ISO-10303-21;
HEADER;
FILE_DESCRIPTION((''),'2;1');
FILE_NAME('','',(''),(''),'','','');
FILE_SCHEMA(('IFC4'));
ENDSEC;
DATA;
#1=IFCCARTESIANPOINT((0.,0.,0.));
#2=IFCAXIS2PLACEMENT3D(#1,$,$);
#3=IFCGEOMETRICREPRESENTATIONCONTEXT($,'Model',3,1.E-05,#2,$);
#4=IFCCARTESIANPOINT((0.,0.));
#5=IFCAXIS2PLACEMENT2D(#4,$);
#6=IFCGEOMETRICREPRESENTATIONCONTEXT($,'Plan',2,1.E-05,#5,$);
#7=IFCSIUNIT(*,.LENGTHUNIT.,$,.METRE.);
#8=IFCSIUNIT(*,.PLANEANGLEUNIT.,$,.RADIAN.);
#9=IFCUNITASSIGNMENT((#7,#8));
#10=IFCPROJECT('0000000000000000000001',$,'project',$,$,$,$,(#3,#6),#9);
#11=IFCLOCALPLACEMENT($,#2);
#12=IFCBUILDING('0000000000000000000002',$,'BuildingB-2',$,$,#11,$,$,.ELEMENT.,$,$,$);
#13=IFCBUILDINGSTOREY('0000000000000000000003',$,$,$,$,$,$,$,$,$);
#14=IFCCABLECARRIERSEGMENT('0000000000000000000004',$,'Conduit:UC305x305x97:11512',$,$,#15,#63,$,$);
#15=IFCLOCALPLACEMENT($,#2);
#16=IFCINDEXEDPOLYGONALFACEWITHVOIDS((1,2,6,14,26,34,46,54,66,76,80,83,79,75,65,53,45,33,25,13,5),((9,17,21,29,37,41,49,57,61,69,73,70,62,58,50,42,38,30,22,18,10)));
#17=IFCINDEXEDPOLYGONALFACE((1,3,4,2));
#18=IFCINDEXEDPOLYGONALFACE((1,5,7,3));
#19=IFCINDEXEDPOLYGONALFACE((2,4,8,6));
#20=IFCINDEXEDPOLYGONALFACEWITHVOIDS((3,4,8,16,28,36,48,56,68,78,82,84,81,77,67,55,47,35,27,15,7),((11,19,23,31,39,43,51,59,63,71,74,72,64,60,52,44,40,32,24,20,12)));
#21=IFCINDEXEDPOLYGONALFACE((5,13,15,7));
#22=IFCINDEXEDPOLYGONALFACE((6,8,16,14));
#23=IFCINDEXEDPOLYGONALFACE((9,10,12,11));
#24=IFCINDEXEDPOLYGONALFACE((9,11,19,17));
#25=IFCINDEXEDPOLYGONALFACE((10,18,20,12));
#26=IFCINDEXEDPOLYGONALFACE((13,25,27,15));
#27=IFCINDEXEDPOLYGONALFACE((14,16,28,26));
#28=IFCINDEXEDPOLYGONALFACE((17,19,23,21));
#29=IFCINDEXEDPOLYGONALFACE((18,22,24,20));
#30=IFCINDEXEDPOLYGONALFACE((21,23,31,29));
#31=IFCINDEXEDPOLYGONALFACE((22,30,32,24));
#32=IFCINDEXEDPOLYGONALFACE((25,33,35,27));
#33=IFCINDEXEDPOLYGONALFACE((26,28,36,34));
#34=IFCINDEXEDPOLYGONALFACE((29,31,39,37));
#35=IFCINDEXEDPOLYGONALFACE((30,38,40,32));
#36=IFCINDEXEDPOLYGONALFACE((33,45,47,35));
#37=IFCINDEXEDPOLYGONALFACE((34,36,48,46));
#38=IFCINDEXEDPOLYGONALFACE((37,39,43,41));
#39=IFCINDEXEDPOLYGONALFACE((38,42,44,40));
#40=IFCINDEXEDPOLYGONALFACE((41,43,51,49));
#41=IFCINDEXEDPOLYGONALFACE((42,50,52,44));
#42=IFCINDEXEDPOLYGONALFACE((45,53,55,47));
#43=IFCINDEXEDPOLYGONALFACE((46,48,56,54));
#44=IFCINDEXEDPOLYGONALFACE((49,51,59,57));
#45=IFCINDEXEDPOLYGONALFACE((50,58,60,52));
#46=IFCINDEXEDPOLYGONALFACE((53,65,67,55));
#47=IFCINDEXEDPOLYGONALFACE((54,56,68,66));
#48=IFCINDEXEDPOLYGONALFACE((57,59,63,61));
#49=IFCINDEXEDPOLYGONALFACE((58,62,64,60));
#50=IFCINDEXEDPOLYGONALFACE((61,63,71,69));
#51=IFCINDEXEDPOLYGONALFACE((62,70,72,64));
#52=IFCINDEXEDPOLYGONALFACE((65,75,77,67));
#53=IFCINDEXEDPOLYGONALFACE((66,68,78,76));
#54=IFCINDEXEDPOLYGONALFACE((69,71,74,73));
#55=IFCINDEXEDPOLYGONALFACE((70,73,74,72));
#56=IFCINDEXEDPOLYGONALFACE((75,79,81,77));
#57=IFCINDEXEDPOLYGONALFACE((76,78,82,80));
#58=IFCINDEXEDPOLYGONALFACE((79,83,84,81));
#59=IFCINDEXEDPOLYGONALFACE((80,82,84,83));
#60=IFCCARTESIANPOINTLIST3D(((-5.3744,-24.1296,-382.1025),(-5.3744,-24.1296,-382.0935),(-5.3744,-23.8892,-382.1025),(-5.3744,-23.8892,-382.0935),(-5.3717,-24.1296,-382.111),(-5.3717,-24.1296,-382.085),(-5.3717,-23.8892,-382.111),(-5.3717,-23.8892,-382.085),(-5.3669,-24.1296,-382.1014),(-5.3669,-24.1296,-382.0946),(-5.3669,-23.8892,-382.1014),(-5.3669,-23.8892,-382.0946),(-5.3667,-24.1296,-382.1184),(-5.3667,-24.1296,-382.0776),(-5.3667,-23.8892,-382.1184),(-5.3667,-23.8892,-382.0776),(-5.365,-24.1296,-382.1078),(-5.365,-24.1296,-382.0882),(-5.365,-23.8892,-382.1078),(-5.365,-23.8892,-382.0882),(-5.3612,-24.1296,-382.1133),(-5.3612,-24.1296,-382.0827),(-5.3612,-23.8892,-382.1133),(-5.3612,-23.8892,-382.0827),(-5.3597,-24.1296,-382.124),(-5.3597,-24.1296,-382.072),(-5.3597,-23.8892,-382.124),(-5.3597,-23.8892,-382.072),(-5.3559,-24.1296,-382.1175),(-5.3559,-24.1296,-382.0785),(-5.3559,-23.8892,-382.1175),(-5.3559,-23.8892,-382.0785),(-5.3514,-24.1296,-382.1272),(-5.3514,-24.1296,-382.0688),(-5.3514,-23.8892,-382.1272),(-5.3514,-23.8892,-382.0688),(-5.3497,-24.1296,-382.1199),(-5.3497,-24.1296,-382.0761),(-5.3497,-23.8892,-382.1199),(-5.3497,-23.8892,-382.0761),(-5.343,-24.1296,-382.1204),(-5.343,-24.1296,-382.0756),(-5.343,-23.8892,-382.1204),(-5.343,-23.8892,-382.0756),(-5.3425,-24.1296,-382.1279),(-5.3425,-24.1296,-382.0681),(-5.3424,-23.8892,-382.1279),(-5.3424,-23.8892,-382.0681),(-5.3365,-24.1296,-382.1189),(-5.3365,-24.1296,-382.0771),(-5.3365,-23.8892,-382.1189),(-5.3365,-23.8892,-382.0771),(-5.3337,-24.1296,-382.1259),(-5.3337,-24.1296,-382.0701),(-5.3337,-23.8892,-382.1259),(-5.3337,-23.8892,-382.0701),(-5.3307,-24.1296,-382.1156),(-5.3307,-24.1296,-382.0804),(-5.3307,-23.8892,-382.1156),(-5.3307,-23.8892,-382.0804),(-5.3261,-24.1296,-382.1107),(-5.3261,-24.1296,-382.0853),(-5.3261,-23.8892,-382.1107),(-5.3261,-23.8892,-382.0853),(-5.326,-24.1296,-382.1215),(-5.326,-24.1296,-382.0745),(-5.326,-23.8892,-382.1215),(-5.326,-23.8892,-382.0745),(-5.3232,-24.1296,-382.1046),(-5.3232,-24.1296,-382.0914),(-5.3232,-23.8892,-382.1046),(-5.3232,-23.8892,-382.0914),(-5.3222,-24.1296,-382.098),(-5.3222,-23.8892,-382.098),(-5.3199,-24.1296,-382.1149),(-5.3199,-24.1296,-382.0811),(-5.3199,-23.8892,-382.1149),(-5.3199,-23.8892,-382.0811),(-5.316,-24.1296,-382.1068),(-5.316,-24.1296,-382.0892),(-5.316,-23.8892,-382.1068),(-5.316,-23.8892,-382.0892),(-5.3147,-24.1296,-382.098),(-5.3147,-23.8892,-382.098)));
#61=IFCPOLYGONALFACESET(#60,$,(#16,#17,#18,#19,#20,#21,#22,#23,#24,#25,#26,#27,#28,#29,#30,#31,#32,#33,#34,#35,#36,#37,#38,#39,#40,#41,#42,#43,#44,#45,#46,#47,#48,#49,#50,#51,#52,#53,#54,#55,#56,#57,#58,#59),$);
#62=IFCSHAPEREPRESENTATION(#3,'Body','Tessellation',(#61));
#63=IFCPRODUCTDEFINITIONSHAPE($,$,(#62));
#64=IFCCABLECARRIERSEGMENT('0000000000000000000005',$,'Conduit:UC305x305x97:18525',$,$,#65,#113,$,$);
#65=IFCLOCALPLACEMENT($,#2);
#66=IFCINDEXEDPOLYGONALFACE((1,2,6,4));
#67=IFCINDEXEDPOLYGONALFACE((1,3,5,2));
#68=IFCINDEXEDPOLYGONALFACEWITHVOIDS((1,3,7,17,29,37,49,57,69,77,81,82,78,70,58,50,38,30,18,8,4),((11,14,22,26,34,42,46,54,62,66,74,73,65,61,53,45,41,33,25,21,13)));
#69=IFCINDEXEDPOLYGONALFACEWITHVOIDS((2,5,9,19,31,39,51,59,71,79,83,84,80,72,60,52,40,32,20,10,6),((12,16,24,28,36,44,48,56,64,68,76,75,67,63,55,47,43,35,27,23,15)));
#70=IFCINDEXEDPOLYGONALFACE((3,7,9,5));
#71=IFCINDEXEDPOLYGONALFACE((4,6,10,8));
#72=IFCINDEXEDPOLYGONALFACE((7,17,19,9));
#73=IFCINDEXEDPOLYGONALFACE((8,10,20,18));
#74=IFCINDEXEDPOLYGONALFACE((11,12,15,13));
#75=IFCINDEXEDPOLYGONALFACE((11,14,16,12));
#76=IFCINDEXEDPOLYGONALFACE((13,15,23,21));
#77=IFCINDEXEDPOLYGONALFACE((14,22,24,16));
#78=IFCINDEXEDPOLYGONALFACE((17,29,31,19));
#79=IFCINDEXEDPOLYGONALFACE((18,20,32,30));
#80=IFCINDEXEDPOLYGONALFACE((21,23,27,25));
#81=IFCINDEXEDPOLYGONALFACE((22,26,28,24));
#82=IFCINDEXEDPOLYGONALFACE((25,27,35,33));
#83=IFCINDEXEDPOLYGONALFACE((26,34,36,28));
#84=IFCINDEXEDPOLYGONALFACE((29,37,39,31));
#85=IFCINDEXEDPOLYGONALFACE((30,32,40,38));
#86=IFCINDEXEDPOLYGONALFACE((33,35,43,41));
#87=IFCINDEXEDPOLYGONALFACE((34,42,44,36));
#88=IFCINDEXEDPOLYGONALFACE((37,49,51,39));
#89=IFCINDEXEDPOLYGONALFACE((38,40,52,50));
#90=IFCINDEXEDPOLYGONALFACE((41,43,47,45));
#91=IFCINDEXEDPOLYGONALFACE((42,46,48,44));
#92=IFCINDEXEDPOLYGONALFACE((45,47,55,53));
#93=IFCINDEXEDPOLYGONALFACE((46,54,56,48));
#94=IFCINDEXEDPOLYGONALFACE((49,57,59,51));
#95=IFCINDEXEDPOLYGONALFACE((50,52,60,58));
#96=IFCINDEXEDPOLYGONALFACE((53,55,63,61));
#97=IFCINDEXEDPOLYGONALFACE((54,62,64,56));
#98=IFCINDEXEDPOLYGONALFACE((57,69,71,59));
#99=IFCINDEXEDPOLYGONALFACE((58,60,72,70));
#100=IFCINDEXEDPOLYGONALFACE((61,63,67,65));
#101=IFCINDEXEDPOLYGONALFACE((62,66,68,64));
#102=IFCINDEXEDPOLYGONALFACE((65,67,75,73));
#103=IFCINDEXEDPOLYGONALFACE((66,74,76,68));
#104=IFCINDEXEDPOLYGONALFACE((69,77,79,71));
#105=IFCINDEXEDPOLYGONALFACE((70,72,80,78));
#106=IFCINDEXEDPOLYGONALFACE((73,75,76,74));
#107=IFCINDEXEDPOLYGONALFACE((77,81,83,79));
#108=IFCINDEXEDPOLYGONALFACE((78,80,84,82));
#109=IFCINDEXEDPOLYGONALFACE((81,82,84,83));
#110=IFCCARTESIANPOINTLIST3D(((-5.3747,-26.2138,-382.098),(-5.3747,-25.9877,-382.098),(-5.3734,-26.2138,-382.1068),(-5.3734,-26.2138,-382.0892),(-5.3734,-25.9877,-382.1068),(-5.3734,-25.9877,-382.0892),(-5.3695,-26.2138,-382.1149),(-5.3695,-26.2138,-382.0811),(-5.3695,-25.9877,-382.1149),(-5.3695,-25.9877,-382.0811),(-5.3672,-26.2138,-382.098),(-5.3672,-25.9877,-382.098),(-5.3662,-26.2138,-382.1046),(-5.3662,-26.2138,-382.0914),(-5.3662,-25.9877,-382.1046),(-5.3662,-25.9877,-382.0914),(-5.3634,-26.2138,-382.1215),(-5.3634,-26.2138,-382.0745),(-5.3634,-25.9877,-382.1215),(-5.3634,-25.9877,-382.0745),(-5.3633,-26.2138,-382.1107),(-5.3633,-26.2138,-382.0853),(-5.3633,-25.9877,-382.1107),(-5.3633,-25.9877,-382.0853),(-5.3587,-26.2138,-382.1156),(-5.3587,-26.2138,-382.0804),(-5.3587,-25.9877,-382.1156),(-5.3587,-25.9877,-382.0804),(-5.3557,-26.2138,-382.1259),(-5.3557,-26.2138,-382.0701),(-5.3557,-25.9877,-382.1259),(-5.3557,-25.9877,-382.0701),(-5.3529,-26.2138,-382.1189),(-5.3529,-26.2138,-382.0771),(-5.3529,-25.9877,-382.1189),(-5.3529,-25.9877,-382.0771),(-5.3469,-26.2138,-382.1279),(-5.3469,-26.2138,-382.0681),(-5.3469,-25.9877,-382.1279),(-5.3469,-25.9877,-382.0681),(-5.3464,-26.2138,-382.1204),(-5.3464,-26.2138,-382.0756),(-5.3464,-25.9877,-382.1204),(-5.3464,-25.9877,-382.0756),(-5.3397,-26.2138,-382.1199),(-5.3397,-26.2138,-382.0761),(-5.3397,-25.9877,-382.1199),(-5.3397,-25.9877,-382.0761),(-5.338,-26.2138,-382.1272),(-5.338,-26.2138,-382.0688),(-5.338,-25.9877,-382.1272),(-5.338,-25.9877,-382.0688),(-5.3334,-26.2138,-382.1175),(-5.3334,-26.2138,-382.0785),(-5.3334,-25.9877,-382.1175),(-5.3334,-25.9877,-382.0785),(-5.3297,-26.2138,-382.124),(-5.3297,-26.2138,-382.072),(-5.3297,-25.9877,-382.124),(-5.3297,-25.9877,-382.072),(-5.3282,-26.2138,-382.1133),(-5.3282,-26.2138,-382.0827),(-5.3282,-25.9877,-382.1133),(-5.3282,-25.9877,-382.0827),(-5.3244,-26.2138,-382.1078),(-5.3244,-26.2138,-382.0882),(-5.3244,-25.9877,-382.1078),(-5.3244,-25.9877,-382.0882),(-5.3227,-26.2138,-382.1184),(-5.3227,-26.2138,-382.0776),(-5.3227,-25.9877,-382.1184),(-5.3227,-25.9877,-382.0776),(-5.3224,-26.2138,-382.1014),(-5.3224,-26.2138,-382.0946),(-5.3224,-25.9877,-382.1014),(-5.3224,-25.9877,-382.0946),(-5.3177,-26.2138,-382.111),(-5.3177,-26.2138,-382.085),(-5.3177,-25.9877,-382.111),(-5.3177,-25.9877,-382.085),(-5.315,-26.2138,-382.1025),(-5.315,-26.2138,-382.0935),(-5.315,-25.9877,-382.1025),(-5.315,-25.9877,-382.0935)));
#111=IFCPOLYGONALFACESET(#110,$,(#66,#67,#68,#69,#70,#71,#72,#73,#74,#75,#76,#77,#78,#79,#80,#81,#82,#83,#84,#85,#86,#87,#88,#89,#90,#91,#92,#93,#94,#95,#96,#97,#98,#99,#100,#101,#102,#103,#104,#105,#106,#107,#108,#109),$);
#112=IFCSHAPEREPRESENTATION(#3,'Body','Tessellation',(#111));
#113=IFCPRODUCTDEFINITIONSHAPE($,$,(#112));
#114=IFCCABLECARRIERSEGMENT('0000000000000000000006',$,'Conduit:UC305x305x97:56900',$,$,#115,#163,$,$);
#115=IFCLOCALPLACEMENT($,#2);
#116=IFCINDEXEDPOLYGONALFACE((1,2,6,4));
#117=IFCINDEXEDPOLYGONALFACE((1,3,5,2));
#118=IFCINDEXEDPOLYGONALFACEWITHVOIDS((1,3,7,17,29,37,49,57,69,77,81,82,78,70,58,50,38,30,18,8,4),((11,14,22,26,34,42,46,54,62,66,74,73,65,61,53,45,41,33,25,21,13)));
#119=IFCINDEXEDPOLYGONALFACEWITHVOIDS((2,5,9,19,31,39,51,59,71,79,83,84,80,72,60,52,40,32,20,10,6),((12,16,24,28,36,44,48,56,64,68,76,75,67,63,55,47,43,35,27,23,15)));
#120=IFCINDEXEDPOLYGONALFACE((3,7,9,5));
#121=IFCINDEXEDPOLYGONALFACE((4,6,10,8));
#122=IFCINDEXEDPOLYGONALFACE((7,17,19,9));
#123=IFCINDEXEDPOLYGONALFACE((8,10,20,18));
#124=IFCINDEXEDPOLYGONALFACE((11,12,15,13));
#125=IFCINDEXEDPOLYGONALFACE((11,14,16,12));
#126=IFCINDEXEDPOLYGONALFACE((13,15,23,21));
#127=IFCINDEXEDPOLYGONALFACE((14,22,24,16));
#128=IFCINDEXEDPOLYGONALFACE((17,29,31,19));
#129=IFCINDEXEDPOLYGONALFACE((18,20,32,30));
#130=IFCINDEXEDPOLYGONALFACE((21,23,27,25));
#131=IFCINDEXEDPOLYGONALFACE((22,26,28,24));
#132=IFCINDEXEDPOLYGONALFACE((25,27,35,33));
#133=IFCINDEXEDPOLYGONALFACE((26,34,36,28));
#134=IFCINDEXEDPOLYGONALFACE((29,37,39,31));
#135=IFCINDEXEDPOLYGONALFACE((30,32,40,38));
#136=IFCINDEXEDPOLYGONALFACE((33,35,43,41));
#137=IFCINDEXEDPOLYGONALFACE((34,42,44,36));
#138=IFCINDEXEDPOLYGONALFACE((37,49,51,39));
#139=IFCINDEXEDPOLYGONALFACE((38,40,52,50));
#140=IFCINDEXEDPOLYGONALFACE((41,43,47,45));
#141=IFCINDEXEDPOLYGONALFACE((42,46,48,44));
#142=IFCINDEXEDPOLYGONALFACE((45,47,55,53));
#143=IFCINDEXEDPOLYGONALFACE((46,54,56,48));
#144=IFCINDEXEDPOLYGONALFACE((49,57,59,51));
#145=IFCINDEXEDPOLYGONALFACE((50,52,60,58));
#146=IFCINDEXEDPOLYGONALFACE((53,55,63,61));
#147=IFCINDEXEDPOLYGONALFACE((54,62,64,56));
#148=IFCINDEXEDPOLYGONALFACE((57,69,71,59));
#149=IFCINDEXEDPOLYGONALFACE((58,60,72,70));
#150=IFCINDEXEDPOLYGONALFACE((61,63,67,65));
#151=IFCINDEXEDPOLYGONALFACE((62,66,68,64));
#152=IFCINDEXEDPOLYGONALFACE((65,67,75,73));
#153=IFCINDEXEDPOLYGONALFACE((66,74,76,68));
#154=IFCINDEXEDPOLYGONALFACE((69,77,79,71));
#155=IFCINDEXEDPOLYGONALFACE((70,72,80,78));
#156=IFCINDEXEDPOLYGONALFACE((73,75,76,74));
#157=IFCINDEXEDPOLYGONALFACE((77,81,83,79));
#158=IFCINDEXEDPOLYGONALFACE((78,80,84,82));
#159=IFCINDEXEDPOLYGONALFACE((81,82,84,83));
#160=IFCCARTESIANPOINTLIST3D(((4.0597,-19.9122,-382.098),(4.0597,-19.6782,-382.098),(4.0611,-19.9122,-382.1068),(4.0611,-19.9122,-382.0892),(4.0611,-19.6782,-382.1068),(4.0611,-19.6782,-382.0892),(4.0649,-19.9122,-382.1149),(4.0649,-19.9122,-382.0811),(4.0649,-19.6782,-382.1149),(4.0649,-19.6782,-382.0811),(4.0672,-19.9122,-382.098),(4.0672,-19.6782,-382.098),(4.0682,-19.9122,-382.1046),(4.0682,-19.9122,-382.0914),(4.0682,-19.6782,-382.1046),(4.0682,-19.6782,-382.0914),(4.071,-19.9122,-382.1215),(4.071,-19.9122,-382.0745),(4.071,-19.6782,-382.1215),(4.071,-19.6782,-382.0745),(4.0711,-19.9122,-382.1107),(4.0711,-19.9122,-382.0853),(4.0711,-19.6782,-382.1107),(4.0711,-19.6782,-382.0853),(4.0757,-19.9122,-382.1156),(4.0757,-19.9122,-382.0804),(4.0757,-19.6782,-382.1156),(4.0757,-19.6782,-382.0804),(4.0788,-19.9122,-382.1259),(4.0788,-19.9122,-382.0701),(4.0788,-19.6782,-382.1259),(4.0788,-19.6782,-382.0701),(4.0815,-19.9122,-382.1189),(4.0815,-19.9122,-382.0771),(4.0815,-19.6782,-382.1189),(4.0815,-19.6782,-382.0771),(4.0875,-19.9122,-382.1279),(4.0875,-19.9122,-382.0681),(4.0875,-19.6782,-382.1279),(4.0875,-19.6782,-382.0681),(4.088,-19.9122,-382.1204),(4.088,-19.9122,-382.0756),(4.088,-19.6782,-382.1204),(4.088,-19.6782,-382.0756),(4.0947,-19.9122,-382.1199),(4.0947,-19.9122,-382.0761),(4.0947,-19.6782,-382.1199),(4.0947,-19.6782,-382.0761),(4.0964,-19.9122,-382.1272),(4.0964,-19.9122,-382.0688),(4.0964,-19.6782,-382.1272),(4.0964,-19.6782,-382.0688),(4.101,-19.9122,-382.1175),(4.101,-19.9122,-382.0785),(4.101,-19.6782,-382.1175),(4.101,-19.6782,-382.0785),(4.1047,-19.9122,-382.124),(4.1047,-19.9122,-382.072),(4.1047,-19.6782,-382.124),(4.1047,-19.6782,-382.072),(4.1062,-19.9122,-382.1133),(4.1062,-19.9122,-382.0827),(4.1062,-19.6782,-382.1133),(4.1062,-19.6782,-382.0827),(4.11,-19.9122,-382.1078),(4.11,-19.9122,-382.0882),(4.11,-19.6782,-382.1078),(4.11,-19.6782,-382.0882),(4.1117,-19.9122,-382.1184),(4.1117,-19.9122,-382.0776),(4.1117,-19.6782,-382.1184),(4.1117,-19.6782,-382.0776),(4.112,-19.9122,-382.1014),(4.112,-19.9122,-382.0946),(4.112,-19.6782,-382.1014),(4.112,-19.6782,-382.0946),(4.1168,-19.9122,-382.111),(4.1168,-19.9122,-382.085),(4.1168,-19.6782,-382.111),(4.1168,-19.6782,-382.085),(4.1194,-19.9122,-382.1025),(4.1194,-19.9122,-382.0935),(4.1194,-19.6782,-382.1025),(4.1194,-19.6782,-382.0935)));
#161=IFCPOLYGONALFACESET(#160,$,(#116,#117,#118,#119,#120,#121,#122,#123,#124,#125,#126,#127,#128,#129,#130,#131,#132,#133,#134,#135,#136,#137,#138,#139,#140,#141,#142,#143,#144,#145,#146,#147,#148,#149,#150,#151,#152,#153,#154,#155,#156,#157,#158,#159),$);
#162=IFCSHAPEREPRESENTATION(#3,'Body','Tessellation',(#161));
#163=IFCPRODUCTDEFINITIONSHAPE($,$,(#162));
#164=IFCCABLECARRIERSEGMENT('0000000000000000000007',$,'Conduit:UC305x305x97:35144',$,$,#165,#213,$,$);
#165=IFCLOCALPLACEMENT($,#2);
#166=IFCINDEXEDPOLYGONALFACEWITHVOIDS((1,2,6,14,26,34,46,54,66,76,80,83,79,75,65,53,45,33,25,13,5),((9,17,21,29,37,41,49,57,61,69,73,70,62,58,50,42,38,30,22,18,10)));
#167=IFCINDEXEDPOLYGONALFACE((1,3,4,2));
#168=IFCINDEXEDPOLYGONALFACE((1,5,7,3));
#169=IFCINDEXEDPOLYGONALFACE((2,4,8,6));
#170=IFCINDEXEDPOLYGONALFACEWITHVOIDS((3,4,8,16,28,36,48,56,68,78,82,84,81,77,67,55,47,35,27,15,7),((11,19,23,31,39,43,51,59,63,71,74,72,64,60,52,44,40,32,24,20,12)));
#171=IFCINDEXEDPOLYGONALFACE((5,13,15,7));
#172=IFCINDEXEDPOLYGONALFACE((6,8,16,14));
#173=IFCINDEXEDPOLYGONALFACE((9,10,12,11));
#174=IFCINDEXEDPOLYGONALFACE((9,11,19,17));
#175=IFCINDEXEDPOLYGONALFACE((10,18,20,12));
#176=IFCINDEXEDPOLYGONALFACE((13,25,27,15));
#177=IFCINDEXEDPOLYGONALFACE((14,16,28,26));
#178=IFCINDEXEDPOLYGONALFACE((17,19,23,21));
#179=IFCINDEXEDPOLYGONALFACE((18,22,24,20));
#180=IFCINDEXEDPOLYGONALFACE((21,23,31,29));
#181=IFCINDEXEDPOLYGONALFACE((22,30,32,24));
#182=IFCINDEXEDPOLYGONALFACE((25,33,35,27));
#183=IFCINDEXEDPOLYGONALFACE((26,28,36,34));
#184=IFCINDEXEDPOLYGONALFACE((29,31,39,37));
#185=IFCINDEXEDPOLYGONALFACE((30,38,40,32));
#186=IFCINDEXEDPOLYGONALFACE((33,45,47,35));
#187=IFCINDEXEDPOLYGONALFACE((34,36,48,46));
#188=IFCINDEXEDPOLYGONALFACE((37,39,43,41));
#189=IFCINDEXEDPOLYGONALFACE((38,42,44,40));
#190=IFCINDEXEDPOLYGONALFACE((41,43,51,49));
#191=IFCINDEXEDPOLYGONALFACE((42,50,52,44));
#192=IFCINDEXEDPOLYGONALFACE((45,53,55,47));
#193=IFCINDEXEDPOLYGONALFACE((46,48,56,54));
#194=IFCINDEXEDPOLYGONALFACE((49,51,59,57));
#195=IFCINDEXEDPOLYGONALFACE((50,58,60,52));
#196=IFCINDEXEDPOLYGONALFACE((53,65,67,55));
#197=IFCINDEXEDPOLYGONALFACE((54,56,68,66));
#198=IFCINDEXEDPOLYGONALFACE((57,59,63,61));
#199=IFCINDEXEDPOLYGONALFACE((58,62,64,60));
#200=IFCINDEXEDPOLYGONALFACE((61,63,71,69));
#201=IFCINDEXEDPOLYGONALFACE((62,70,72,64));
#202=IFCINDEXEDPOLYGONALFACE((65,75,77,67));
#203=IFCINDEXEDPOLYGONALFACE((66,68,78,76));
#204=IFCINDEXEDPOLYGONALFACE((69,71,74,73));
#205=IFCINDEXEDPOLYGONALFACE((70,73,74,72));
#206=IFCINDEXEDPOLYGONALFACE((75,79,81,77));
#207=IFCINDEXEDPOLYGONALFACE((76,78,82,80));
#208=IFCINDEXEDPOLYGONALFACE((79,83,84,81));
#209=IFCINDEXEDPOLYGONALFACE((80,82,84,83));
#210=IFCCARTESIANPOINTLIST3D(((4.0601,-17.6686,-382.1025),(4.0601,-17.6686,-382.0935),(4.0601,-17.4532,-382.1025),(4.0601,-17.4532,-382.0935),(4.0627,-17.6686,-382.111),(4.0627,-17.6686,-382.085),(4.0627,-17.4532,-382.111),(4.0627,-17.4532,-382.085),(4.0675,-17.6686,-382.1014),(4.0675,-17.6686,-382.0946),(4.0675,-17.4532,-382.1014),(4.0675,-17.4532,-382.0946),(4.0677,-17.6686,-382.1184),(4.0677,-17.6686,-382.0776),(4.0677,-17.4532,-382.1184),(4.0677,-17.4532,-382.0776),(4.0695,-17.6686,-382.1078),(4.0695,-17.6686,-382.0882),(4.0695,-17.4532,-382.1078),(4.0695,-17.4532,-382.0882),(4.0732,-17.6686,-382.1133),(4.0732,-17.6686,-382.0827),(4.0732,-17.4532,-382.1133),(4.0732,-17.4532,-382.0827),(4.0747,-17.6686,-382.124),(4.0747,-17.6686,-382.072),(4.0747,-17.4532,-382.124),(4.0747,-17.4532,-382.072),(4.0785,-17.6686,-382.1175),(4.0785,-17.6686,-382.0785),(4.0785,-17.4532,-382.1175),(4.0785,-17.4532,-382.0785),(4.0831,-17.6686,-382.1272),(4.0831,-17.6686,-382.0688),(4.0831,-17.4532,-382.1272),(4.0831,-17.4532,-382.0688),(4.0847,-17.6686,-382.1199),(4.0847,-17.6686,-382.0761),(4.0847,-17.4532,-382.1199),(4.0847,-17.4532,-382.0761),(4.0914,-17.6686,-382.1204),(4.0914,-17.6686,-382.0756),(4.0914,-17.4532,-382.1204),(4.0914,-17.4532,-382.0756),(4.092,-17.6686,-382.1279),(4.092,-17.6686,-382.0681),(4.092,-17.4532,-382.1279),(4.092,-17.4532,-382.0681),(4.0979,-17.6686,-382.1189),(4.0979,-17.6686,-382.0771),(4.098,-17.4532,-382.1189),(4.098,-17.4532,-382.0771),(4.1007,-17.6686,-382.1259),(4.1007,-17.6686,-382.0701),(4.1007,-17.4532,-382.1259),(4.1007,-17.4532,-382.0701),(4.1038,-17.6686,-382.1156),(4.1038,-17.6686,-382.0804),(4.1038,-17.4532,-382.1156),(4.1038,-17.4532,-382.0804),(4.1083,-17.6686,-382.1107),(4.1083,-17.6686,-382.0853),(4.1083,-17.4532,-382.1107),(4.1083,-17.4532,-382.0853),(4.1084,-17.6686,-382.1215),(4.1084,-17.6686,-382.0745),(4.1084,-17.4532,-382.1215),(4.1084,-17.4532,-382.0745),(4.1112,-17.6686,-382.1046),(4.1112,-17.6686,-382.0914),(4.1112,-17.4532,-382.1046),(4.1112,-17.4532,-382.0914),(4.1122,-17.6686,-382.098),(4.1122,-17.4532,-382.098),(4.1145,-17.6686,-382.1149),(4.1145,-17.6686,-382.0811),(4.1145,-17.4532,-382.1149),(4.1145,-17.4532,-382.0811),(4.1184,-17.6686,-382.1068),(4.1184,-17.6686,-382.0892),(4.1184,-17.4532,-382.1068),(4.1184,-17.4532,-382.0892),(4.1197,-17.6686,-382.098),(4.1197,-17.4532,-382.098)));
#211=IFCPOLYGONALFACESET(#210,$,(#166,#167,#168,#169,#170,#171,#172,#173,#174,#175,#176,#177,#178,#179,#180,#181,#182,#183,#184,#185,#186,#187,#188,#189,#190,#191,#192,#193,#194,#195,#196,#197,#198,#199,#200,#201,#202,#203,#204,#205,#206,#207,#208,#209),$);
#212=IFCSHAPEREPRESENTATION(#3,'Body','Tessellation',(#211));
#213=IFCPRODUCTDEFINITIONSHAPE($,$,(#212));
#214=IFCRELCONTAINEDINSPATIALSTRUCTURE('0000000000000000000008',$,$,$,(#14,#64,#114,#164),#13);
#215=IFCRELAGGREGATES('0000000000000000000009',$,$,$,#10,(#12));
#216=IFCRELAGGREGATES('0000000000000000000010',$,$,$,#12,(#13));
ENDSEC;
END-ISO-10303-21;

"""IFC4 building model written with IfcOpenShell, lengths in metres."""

from ifc_helpers import new_model, entity, si_unit, origin, origin_2d, place, context, project, spatial, element, save


model = new_model("IFC4")

# Units and contexts
model_context = context("Model", 3, precision=1e-05, world=origin())
plan_context = context("Plan", 2, precision=1e-05, world=origin_2d())
ifc_project = project(units=[si_unit("LENGTHUNIT", "METRE"), si_unit("PLANEANGLEUNIT", "RADIAN")], contexts=[model_context, plan_context])

# Building, storey
building_placement = place(None, origin())
building = spatial("IfcBuilding", under=ifc_project, at=building_placement, Name="BuildingB-2", CompositionType="ELEMENT")
storey = spatial("IfcBuildingStorey", under=building)

# Cable carrier segments
element("IfcCableCarrierSegment", 1, inside=storey, Name="Conduit:UC305x305x97:11512", context=model_context, shape_type="AdvancedSweptSolid", body=[
    entity("IfcSweptDiskSolid", entity("IfcCompositeCurve", [entity("IfcCompositeCurveSegment", "CONTINUOUS", False, entity("IfcPolyline", [entity("IfcCartesianPoint", [5.3447, 23.8892, 382.098]), entity("IfcCartesianPoint", [5.3447, 24.1296, 382.098])]))], False), 0.03, 0.0225),
])
element("IfcCableCarrierSegment", 2, inside=storey, Name="Conduit:UC305x305x97:18525", context=model_context, shape_type="AdvancedSweptSolid", body=[
    entity("IfcSweptDiskSolid", entity("IfcCompositeCurve", [entity("IfcCompositeCurveSegment", "CONTINUOUS", False, entity("IfcPolyline", [entity("IfcCartesianPoint", [5.3447, 26.2138, 382.098]), entity("IfcCartesianPoint", [5.3447, 25.9877, 382.098])]))], False), 0.03, 0.0225),
])
element("IfcCableCarrierSegment", 3, inside=storey, Name="Conduit:UC305x305x97:56900", context=model_context, shape_type="AdvancedSweptSolid", body=[
    entity("IfcSweptDiskSolid", entity("IfcCompositeCurve", [entity("IfcCompositeCurveSegment", "CONTINUOUS", False, entity("IfcPolyline", [entity("IfcCartesianPoint", [-4.0897, 19.9122, 382.098]), entity("IfcCartesianPoint", [-4.0897, 19.6782, 382.098])]))], False), 0.03, 0.0225),
])
element("IfcCableCarrierSegment", 4, inside=storey, Name="Conduit:UC305x305x97:35144", context=model_context, shape_type="AdvancedSweptSolid", body=[
    entity("IfcSweptDiskSolid", entity("IfcCompositeCurve", [entity("IfcCompositeCurveSegment", "CONTINUOUS", False, entity("IfcPolyline", [entity("IfcCartesianPoint", [-4.0897, 17.4532, 382.098]), entity("IfcCartesianPoint", [-4.0897, 17.6686, 382.098])]))], False), 0.03, 0.0225),
])

save(model, "model.ifc")
